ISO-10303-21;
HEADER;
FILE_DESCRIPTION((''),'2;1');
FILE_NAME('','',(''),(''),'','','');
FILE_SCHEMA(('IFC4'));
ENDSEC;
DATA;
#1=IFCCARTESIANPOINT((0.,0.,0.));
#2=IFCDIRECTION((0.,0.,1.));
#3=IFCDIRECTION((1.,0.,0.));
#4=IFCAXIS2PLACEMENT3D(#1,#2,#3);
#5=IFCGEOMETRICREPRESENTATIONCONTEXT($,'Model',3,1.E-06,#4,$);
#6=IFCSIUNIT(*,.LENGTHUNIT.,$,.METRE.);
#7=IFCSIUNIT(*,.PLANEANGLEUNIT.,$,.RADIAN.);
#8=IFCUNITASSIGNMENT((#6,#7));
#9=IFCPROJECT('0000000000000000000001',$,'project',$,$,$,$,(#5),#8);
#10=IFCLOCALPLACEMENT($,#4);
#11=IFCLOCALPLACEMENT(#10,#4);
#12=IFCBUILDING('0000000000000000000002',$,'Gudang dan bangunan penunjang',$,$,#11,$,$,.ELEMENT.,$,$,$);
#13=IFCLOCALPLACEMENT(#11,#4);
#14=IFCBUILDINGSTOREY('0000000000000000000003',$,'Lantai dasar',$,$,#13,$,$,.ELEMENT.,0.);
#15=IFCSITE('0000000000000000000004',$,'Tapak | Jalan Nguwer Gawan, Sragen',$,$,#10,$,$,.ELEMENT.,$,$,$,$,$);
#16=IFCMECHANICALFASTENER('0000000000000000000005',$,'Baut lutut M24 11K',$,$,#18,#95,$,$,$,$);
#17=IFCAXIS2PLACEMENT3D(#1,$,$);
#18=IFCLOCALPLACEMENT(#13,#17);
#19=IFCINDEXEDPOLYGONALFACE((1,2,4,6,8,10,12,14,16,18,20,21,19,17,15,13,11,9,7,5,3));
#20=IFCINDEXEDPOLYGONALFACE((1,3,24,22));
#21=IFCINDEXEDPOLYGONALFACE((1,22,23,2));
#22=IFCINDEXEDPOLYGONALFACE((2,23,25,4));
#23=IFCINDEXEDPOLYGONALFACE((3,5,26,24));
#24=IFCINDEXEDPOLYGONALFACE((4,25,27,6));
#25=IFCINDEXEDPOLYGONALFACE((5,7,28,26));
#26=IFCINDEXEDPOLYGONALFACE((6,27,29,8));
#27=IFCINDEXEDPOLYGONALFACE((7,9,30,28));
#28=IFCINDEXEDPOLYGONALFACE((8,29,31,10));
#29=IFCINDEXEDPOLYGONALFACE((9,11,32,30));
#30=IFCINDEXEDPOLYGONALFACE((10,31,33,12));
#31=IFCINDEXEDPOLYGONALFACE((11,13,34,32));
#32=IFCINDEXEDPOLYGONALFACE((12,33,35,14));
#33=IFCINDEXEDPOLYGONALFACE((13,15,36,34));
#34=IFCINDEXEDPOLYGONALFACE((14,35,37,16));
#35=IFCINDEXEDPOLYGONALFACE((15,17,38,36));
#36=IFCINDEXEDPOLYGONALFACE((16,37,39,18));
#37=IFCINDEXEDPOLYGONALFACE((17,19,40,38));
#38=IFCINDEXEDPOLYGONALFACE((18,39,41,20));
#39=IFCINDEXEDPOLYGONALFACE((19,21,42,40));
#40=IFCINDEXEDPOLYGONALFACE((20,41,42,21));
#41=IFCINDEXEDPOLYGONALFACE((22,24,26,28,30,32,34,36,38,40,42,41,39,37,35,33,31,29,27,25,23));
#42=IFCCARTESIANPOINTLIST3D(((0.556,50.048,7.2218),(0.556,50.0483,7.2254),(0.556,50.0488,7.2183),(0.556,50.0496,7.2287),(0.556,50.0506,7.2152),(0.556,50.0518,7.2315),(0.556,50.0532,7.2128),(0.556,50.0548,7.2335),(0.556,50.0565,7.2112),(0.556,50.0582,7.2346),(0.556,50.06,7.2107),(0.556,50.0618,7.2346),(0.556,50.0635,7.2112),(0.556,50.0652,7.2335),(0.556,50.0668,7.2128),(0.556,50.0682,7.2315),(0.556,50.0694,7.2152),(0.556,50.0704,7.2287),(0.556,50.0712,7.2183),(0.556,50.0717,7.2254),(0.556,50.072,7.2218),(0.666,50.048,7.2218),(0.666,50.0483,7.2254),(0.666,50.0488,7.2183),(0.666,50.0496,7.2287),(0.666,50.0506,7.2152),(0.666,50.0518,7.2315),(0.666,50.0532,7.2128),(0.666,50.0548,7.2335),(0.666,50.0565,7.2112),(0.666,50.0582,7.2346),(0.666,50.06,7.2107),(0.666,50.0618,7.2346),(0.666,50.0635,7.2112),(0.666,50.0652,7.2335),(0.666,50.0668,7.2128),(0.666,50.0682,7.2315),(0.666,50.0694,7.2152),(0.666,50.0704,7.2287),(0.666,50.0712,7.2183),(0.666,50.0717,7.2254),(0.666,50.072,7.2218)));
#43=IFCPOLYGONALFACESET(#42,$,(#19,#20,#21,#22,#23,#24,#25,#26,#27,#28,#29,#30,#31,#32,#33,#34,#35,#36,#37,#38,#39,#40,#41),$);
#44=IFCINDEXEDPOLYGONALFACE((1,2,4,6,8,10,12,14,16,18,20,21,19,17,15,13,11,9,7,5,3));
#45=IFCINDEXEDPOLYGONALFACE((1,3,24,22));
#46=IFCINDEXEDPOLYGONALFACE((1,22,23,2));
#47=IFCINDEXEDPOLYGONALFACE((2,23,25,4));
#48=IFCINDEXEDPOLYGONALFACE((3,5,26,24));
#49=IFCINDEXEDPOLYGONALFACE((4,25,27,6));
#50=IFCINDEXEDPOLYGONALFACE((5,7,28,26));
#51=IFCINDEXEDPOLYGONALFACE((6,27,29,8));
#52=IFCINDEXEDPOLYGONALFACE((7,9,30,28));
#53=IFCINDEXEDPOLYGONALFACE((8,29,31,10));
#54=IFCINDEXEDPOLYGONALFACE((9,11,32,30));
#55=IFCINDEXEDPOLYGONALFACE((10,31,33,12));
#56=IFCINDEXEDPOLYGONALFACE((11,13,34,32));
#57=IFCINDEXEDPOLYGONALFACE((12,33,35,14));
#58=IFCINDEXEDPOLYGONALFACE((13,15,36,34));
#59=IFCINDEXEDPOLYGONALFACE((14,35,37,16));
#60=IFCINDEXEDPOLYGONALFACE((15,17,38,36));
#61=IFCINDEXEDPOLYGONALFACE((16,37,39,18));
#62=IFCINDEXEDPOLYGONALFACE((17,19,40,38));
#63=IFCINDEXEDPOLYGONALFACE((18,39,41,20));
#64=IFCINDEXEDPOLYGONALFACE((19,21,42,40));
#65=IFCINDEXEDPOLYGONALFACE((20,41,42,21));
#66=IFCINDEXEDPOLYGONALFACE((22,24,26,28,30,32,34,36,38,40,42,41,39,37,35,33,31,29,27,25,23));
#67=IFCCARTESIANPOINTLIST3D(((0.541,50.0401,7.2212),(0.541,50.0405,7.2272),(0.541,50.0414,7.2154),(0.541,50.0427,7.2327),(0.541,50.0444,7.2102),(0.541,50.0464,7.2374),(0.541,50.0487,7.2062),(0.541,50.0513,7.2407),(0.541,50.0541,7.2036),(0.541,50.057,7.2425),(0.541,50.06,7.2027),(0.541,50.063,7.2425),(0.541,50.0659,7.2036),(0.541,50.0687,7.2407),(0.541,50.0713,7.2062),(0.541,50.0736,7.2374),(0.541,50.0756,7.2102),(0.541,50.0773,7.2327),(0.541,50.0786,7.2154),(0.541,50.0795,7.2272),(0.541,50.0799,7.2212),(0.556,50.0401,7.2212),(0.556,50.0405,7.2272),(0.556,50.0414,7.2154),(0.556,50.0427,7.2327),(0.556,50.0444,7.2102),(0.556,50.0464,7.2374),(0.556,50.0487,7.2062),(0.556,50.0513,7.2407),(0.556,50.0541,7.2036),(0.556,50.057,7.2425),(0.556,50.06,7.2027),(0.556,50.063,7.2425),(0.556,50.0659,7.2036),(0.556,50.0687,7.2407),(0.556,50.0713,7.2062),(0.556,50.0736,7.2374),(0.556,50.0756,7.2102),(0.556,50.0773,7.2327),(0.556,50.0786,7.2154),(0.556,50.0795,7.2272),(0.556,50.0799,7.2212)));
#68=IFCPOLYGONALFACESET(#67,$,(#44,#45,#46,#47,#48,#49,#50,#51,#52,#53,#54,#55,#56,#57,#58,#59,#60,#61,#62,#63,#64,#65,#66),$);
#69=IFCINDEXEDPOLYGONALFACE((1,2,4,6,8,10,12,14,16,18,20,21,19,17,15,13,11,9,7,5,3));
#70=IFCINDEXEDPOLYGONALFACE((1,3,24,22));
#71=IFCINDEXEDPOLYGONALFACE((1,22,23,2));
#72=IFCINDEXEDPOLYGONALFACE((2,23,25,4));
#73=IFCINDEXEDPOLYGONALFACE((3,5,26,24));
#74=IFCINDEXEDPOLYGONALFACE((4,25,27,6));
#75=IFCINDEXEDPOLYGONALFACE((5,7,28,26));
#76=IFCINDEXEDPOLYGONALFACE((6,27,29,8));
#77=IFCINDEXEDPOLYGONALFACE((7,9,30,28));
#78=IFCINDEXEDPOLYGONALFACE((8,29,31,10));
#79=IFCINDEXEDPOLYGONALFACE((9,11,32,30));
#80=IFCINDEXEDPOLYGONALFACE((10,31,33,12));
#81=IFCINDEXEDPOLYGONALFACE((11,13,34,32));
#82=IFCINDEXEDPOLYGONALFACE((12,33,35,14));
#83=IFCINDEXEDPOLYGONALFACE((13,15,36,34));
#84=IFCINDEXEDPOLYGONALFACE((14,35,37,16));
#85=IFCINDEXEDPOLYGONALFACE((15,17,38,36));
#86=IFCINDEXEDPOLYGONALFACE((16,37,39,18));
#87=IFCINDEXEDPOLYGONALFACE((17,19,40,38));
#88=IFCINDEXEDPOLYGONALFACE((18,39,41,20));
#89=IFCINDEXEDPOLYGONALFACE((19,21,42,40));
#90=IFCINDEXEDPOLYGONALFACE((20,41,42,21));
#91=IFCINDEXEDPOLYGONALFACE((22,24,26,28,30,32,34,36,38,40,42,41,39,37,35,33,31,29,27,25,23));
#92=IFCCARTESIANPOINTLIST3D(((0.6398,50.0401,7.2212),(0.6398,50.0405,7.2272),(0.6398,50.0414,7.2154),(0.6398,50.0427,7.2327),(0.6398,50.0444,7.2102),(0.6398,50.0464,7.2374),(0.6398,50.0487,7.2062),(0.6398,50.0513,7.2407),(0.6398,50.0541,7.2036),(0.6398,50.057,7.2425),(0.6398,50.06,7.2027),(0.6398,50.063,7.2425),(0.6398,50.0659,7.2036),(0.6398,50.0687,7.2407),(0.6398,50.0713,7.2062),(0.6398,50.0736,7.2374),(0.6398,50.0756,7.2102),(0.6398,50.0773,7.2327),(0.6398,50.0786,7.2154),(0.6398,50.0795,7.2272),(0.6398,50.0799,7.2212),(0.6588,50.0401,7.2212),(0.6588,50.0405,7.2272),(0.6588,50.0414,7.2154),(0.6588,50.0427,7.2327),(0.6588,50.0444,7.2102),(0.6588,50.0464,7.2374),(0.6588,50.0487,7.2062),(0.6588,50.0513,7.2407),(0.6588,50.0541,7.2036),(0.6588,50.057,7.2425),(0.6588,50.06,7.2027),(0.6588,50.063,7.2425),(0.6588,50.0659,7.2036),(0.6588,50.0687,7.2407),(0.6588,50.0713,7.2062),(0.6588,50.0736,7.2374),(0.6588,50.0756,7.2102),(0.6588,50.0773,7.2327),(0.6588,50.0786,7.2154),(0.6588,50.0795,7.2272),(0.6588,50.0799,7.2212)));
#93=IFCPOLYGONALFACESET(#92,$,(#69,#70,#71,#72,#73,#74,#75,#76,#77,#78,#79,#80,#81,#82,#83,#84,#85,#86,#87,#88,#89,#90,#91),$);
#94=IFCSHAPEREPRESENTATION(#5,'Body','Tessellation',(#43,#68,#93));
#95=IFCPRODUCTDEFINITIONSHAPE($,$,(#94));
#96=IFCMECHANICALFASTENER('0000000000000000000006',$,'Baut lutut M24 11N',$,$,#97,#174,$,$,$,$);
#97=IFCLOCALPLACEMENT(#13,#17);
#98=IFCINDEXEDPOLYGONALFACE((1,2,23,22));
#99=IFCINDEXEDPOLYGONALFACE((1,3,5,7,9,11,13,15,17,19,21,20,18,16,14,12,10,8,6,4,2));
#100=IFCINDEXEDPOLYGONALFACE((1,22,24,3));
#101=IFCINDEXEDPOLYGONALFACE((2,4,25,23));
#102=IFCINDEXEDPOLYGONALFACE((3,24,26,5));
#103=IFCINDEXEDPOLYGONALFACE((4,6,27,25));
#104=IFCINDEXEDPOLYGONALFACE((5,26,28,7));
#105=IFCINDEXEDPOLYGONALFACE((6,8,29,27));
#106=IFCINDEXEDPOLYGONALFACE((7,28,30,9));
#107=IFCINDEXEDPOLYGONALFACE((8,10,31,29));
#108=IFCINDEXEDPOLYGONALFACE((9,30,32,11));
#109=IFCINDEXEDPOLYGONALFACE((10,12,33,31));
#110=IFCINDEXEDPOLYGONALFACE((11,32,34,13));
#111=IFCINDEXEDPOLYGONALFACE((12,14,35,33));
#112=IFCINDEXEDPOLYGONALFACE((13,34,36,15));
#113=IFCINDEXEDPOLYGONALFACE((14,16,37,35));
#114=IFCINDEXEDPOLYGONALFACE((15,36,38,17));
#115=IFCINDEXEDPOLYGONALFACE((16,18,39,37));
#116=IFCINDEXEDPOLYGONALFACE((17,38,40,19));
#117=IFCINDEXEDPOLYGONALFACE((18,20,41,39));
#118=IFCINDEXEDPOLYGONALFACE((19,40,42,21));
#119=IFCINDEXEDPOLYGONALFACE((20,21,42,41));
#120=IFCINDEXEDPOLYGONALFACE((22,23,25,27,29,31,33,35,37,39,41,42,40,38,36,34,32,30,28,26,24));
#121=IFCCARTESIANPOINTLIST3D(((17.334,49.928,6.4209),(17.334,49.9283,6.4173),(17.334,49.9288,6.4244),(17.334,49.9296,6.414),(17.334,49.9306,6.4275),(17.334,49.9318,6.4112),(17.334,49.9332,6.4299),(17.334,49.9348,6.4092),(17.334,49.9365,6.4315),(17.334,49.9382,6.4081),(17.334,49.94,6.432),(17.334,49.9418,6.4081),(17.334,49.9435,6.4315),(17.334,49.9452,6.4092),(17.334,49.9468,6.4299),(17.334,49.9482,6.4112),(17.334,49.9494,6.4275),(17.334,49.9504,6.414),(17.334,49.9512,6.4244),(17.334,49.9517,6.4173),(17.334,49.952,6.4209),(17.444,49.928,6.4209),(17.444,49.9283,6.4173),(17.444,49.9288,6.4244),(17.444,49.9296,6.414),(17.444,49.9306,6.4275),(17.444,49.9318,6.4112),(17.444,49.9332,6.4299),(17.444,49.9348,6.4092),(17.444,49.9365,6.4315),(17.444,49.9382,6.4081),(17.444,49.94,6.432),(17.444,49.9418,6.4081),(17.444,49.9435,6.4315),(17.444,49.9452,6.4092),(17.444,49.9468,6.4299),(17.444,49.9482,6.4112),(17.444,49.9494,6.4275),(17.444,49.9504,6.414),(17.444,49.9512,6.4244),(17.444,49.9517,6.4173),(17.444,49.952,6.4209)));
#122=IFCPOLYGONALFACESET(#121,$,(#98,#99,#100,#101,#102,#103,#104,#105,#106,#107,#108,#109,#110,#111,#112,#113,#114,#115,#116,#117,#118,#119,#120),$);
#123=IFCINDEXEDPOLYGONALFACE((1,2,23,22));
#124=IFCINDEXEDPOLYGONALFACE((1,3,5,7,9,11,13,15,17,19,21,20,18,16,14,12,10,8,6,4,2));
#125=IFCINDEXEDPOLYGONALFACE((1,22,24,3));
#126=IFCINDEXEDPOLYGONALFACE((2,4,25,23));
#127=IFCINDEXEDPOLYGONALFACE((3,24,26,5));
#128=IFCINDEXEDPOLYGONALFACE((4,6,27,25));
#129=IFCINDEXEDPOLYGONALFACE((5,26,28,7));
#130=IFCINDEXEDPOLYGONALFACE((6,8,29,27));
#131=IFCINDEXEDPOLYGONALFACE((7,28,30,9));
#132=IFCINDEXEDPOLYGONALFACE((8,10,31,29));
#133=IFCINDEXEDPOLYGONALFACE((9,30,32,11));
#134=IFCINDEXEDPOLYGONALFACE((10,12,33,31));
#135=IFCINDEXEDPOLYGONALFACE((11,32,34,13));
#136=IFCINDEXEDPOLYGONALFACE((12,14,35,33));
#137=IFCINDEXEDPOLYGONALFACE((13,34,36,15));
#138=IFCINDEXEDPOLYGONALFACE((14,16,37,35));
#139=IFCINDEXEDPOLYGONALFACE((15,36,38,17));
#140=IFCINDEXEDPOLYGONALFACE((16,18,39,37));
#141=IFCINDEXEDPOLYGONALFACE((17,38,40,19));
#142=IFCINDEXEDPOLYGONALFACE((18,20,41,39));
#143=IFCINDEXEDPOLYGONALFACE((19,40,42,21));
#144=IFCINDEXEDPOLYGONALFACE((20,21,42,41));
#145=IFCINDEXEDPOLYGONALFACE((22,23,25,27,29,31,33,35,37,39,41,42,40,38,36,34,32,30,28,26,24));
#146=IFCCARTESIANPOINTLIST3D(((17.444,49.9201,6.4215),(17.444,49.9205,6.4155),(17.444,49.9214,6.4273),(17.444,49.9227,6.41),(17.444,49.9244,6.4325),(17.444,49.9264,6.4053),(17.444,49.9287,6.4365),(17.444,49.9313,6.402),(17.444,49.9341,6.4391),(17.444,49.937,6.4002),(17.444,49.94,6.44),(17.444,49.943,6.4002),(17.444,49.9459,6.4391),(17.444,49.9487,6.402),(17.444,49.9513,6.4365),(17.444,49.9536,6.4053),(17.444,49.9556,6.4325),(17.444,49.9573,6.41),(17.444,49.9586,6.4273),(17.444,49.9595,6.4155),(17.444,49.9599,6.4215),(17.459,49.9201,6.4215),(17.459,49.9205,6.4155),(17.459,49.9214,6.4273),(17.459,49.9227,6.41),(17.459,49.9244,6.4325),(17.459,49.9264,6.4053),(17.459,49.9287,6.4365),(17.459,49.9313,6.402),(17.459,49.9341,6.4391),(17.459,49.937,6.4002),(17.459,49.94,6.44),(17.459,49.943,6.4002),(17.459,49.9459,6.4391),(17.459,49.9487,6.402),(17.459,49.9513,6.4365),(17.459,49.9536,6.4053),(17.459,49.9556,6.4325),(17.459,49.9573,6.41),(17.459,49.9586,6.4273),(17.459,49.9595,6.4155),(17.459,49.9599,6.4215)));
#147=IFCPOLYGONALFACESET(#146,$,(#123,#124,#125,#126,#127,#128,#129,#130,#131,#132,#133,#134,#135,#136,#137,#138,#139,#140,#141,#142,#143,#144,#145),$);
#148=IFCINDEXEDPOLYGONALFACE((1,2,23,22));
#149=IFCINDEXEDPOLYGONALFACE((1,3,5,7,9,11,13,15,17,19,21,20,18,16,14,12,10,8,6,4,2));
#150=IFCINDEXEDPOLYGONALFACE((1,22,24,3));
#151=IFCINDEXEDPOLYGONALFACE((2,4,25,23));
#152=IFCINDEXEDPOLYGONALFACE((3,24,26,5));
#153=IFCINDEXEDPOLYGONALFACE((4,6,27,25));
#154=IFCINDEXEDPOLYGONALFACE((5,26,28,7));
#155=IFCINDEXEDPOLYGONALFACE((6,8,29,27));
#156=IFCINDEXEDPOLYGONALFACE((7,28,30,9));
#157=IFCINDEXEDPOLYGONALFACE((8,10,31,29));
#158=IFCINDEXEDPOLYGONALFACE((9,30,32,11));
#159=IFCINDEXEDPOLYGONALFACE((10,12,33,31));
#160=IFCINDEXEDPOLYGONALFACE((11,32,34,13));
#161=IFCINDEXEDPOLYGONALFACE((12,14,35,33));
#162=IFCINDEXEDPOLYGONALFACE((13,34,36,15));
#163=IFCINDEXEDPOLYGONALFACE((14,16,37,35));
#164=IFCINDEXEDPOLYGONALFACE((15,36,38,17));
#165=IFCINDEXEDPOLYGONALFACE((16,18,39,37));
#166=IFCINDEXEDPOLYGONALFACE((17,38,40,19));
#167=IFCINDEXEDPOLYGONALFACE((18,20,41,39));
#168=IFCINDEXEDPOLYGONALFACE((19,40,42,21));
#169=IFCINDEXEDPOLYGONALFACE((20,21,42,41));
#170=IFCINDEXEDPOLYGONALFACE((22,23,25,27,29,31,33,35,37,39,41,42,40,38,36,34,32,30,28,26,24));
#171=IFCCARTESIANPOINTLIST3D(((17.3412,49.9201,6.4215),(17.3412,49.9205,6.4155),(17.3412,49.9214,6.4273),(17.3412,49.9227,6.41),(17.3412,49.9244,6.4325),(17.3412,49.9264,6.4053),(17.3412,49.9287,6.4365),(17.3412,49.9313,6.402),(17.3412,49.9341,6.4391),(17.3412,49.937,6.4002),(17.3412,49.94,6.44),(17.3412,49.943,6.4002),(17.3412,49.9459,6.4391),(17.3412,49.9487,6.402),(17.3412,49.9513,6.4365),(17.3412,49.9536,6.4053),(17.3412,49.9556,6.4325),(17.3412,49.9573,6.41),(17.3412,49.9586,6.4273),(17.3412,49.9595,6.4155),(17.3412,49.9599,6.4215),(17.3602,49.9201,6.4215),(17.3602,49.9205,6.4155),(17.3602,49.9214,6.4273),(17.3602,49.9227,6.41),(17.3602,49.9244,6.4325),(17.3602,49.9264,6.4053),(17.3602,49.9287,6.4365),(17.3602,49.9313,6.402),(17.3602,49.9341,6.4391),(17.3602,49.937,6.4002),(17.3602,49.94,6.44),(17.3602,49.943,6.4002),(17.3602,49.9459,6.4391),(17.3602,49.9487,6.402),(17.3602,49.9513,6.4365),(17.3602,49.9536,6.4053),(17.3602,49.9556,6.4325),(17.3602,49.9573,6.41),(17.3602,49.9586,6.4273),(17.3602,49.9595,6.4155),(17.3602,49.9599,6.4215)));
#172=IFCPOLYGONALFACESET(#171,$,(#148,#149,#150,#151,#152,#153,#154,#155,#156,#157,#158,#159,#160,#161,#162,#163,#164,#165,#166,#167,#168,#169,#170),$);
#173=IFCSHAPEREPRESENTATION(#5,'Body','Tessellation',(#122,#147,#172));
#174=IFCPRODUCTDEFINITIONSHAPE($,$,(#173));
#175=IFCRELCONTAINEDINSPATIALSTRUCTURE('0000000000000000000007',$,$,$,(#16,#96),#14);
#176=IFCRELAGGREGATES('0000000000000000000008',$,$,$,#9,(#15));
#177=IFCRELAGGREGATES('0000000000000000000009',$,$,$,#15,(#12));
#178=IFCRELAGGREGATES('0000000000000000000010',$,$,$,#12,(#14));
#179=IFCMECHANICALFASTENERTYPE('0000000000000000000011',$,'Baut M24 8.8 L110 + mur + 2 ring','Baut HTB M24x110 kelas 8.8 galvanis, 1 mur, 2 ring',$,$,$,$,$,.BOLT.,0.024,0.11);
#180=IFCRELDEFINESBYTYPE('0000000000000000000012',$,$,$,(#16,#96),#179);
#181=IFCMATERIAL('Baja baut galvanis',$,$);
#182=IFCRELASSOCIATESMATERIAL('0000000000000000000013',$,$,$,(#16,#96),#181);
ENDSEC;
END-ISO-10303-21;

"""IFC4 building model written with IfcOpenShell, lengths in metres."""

from ifc_helpers import new_model, si_unit, frame, origin_with_axes, place, context, project, spatial, circle, extrude, source, transform, mapped, material, type_object, type_shapes, element, save


model = new_model("IFC4")

# Units and contexts
model_context = context("Model", 3, precision=1e-06, world=origin_with_axes())
ifc_project = project(units=[si_unit("LENGTHUNIT", "METRE"), si_unit("PLANEANGLEUNIT", "RADIAN")], contexts=[model_context])

# Site, building, storey
site_placement = place(None, origin_with_axes())
site = spatial("IfcSite", under=ifc_project, at=site_placement, Name="Tapak | Jalan Nguwer Gawan, Sragen", CompositionType="ELEMENT")
building_placement = place(site_placement, origin_with_axes())
building = spatial("IfcBuilding", under=site, at=building_placement, Name="Gudang dan bangunan penunjang", CompositionType="ELEMENT")
storey_placement = place(building_placement, origin_with_axes())
storey = spatial("IfcBuildingStorey", under=building, at=storey_placement, Name="Lantai dasar", CompositionType="ELEMENT", Elevation=0.0)

# Shared definitions
placement = place(None, origin_with_axes())

# Mechanical fasteners
ifc_material_1 = material(Name="Baja baut galvanis")
mechanical_fastener_type_1 = type_object("IfcMechanicalFastenerType", Name="Baut M24 8.8 L110 + mur + 2 ring", Description="Baut HTB M24x110 kelas 8.8 galvanis, 1 mur, 2 ring", NominalDiameter=0.024, NominalLength=0.11, PredefinedType="BOLT")
shared_shape_1 = source(origin_with_axes(), model_context, "Body", "SweptSolid", [
    extrude(circle(Radius=0.012), origin_with_axes(), (0.0, 0.0, 1.0), 0.11),
    extrude(circle(Radius=0.02), frame((0.0, 0.0, -0.015), z_axis=(0.0, 0.0, 1.0), x_axis=(1.0, 0.0, 0.0)), (0.0, 0.0, 1.0), 0.015),
    extrude(circle(Radius=0.02), frame((0.0, 0.0, 0.0838), z_axis=(0.0, 0.0, 1.0), x_axis=(1.0, 0.0, 0.0)), (0.0, 0.0, 1.0), 0.019),
])
type_shapes(mechanical_fastener_type_1, [shared_shape_1])
element("IfcMechanicalFastener", 1, at=placement, inside=storey, type_object=mechanical_fastener_type_1, material=ifc_material_1, Name="Baut lutut M24 11K", context=model_context, shape_type="MappedRepresentation", body=[
    mapped(shared_shape_1, transform((0.556, 50.06, 7.2227), x_axis=(0.0, 0.0, -1.0), y_axis=(0.0, 1.0, 0.0), z_axis=(1.0, 0.0, 0.0), scale=1.0)),
])
element("IfcMechanicalFastener", 2, at=placement, inside=storey, type_object=mechanical_fastener_type_1, material=ifc_material_1, Name="Baut lutut M24 11N", context=model_context, shape_type="MappedRepresentation", body=[
    mapped(shared_shape_1, transform((17.444, 49.94, 6.42), x_axis=(0.0, 0.0, 1.0), y_axis=(0.0, 1.0, 0.0), z_axis=(-1.0, 0.0, 0.0), scale=1.0)),
])

save(model, "model.ifc")
